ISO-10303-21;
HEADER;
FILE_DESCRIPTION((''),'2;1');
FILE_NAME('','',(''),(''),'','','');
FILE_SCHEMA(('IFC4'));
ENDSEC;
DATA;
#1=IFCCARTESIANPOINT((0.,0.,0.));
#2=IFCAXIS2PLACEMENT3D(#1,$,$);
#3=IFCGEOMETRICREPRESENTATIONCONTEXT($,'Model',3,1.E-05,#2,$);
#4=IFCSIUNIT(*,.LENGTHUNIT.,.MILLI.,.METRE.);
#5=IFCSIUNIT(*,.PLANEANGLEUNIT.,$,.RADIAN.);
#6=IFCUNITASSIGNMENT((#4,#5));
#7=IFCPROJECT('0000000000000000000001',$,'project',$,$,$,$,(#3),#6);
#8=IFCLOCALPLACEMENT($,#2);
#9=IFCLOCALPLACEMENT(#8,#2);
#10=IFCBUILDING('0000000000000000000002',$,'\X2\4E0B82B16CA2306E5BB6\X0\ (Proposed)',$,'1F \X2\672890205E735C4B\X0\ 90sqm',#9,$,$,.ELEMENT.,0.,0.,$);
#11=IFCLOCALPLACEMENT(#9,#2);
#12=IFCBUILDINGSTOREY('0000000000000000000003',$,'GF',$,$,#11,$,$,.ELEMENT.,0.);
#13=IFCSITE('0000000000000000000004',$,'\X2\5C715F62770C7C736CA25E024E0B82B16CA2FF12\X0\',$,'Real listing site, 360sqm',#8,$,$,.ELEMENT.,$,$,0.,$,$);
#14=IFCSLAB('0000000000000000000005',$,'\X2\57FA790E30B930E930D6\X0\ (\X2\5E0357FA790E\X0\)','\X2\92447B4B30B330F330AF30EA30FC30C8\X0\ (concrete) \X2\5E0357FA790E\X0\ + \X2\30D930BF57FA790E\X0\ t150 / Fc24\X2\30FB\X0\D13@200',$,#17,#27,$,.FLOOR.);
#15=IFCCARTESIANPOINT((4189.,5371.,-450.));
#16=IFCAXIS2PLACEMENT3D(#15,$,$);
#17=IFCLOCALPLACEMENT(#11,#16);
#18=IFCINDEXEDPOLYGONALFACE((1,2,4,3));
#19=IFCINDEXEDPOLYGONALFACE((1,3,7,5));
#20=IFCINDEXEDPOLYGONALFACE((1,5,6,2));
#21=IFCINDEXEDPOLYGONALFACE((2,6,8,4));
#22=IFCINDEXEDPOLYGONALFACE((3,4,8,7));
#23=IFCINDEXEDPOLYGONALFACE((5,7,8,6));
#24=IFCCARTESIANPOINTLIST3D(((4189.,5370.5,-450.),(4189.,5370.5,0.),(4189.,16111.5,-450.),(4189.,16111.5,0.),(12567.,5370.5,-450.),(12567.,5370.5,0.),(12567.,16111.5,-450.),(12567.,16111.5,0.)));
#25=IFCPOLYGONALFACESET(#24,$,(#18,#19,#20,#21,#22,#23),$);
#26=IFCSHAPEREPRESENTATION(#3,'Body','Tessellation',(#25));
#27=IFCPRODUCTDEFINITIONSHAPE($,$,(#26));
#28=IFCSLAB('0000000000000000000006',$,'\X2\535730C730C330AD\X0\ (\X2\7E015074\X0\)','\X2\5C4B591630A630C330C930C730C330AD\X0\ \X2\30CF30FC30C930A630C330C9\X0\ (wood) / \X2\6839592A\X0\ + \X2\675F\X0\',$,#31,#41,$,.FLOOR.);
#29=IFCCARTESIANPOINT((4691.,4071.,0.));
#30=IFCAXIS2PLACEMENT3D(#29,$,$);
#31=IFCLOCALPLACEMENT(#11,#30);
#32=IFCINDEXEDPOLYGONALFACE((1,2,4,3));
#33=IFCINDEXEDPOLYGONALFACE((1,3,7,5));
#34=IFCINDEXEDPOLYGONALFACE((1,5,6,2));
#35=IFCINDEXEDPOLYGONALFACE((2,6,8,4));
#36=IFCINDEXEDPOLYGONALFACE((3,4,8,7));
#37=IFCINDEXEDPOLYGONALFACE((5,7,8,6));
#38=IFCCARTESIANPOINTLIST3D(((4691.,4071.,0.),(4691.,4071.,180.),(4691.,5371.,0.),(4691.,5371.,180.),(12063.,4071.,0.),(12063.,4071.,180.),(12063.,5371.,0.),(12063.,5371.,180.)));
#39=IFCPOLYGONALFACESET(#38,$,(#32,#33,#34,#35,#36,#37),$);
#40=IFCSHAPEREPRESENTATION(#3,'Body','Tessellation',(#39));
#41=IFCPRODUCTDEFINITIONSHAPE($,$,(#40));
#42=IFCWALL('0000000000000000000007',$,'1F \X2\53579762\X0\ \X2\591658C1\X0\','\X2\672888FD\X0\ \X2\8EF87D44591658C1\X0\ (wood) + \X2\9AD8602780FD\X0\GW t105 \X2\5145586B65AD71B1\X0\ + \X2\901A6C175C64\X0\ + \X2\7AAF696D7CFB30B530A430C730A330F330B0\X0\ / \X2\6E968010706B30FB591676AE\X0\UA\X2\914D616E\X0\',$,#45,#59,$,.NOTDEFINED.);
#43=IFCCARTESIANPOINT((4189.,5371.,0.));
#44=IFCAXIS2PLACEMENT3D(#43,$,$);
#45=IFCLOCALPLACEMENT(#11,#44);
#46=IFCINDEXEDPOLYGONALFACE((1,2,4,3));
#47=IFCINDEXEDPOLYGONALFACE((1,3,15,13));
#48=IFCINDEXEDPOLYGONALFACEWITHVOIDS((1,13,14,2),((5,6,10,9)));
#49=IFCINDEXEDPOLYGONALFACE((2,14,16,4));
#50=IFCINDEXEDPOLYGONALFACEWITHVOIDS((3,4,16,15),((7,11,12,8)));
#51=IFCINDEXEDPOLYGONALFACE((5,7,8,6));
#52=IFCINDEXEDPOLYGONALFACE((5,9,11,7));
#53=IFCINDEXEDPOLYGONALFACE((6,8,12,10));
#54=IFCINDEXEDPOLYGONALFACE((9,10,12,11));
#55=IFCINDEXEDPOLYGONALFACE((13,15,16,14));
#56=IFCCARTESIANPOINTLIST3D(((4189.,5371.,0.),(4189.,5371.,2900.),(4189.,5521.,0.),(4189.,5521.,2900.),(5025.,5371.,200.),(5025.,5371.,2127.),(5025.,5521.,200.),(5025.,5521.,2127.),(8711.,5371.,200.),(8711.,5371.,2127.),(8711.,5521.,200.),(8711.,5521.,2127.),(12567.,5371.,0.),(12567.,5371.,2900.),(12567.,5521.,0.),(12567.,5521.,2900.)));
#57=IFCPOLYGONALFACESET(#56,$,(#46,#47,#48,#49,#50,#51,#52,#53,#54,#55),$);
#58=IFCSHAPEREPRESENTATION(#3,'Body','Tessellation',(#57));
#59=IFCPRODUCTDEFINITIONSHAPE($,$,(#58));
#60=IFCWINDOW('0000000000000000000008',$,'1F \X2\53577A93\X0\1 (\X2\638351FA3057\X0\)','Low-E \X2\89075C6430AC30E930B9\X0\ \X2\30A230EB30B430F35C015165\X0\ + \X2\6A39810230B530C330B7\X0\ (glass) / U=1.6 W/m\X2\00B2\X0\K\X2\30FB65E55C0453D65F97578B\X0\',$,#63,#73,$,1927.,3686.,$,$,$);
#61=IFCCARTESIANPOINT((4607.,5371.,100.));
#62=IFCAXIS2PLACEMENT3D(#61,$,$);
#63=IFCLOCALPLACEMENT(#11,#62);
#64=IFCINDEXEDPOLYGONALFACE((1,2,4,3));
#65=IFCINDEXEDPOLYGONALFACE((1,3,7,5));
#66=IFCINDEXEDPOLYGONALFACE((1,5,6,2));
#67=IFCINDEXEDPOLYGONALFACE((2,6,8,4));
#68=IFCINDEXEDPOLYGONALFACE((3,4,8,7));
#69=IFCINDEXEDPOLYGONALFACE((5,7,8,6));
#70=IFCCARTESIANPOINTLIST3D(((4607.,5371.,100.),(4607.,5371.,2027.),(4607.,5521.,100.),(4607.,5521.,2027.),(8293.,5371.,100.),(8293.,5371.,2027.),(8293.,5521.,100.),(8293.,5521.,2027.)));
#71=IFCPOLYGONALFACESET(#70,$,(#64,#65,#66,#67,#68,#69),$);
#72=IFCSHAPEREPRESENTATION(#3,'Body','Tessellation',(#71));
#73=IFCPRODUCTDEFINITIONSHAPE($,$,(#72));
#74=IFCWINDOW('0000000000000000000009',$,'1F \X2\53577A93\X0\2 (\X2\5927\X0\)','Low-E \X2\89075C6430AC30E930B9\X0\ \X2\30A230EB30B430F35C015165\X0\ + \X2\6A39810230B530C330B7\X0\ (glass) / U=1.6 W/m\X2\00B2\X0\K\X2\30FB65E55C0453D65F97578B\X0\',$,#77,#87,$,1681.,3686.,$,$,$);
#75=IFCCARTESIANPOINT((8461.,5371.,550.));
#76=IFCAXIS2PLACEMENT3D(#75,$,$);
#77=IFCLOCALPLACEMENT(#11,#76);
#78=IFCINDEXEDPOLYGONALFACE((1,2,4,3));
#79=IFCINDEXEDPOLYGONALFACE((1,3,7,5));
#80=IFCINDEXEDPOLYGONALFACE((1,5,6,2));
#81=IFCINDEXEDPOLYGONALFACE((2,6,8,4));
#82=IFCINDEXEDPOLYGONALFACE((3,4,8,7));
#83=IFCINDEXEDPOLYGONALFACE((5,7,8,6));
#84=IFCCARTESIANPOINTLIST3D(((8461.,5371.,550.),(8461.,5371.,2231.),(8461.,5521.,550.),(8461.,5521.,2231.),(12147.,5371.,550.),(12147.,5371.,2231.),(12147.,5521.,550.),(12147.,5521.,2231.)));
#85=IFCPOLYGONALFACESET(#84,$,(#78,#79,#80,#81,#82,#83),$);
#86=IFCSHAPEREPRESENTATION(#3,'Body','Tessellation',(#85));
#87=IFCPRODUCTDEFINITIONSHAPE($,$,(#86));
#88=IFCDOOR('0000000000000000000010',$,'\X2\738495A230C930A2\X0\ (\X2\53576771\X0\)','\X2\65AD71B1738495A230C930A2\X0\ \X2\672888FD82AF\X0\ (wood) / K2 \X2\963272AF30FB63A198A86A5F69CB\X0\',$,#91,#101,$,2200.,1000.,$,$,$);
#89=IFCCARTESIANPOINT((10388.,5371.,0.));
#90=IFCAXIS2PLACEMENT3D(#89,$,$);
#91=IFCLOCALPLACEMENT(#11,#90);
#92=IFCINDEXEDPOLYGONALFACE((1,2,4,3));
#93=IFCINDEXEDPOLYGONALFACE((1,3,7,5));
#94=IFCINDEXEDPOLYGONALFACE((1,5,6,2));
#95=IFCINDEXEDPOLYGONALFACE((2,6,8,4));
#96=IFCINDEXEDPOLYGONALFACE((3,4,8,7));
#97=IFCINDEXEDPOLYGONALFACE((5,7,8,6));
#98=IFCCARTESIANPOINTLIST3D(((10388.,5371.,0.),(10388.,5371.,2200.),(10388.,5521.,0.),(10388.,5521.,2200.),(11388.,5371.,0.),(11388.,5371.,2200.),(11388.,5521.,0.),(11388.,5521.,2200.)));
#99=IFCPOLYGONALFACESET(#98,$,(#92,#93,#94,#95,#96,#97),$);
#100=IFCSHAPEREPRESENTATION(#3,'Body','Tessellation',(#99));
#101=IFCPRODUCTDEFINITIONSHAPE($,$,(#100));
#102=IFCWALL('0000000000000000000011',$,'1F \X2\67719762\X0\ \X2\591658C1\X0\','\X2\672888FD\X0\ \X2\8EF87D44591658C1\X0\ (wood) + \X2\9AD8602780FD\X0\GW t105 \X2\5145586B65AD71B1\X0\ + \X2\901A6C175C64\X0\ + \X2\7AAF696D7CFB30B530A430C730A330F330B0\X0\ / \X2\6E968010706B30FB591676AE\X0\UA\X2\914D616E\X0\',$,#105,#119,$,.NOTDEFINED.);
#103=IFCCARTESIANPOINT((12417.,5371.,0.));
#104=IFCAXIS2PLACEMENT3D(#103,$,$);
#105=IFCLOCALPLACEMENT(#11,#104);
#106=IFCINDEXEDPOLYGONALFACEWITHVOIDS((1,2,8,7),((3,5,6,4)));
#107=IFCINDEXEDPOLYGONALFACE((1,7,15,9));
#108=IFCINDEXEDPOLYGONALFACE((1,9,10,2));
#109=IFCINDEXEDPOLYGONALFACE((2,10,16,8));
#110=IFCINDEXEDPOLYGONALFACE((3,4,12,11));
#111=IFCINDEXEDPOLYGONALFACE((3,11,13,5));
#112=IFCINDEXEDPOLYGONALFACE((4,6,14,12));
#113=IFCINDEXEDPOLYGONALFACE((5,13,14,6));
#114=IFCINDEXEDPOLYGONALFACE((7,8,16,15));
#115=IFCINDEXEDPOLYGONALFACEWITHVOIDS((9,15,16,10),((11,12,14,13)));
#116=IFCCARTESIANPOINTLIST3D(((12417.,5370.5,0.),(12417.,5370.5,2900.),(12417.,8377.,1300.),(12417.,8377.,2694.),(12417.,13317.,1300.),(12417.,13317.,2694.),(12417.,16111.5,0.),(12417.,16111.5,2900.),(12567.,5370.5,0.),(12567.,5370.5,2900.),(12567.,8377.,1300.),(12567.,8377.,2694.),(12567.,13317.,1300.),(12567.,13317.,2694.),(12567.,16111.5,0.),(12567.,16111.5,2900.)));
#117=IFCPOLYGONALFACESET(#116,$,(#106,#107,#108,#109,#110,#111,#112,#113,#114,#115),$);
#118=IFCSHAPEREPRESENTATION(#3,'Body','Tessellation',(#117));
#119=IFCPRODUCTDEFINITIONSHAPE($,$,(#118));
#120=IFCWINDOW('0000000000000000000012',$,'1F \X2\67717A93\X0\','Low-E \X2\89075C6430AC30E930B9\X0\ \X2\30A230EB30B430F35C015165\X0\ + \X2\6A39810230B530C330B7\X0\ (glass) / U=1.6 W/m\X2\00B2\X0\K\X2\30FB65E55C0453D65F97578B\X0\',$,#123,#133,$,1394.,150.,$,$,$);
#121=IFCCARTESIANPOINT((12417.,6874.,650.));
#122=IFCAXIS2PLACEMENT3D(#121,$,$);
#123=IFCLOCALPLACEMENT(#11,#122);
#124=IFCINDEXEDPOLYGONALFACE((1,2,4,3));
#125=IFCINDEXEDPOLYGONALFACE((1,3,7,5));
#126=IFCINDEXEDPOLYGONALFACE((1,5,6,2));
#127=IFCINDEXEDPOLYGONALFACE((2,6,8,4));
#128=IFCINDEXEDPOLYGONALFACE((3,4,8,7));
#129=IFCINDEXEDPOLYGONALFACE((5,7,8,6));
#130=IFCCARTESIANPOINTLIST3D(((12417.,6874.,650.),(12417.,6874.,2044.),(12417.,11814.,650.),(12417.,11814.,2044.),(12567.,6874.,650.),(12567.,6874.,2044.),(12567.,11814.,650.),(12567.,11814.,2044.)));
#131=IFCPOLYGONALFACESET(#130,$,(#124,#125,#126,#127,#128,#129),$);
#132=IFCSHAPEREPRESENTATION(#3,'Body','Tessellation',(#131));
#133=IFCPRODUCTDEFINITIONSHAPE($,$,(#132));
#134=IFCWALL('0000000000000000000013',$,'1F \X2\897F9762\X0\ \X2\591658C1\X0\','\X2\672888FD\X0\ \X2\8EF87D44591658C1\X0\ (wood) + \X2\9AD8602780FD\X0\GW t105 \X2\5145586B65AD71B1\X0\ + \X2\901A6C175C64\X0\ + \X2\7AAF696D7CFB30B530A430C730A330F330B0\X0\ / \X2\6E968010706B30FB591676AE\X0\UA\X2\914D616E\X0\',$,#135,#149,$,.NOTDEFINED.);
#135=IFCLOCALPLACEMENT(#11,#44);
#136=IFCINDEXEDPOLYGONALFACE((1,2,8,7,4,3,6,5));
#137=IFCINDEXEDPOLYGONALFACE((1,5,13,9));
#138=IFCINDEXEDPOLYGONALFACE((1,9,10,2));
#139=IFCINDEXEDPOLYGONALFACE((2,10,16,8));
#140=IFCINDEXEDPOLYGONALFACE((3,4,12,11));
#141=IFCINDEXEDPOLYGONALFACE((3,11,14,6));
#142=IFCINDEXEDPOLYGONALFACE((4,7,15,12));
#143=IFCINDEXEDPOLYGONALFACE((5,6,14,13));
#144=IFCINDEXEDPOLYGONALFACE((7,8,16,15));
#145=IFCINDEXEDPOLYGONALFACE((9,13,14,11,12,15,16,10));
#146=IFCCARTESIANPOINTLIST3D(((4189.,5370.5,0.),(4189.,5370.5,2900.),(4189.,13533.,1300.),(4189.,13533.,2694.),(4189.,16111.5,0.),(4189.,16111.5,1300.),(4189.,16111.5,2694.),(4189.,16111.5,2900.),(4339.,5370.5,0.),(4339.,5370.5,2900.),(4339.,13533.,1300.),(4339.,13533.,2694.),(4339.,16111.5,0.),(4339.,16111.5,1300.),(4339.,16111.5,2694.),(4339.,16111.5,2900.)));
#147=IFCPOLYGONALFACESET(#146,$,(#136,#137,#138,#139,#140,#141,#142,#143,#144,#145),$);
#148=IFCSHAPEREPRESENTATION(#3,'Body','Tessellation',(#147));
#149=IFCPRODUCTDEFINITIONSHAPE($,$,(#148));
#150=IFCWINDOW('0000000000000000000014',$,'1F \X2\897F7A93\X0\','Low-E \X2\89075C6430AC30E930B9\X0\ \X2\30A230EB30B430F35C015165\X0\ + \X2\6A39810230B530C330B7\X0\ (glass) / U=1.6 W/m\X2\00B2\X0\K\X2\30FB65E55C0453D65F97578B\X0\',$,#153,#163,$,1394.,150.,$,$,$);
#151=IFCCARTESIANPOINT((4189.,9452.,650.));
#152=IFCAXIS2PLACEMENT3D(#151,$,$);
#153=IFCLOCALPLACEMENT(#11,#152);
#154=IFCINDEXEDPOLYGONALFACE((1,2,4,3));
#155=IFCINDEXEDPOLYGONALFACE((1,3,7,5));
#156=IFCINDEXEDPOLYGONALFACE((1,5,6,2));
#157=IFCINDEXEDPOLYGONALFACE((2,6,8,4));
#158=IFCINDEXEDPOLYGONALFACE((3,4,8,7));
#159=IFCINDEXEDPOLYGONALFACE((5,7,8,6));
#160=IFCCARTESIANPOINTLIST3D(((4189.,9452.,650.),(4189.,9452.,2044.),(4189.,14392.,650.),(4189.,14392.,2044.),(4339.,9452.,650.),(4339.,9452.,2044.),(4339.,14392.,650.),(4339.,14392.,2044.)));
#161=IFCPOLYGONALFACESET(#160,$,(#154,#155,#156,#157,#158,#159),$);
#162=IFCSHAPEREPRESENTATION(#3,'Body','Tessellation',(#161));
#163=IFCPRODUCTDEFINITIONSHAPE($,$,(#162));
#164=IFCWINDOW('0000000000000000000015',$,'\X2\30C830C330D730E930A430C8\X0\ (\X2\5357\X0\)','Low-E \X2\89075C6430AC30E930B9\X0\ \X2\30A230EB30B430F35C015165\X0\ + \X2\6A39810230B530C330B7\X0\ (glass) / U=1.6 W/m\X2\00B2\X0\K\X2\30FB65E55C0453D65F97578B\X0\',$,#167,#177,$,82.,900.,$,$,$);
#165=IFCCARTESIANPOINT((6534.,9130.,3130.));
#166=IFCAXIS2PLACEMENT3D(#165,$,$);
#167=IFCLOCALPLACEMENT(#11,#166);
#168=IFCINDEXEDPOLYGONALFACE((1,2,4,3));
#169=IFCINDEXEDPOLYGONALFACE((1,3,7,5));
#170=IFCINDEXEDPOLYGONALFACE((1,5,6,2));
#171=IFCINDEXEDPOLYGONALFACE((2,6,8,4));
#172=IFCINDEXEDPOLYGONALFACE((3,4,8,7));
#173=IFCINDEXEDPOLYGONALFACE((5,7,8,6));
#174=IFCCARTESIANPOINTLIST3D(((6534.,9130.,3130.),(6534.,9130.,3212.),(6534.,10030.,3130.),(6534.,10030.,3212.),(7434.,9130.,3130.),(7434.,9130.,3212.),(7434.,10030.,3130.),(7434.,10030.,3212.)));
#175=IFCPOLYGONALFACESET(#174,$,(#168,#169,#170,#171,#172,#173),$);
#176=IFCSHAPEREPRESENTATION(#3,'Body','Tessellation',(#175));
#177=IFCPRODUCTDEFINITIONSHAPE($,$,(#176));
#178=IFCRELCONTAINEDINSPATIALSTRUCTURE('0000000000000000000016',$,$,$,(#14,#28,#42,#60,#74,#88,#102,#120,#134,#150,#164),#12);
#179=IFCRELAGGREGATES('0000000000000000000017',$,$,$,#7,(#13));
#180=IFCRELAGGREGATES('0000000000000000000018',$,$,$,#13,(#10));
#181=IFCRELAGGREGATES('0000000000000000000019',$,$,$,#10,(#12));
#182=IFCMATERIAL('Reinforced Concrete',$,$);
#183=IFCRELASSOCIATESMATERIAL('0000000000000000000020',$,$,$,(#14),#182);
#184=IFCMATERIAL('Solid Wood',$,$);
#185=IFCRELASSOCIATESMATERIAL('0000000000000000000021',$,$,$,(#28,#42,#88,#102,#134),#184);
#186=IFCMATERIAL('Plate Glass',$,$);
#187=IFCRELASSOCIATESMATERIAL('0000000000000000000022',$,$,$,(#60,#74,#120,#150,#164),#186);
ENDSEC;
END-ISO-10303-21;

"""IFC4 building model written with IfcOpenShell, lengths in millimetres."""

from ifc_helpers import new_model, si_unit, frame, frame_2d, origin, place, context, project, spatial, rectangle, extrude, material, element, fill, save


model = new_model("IFC4")

# Units and contexts
model_context = context("Model", 3, precision=1e-05, world=origin())
ifc_project = project(units=[si_unit("LENGTHUNIT", "METRE", prefix="MILLI"), si_unit("PLANEANGLEUNIT", "RADIAN")], contexts=[model_context])

# Site, building, storey
site_placement = place(None, origin())
site = spatial("IfcSite", under=ifc_project, at=site_placement, Name="山形県米沢市下花沢２", ObjectType="Real listing site, 360sqm", CompositionType="ELEMENT", RefElevation=0.0)
building_placement = place(site_placement, origin())
building = spatial("IfcBuilding", under=site, at=building_placement, Name="下花沢の家 (Proposed)", ObjectType="1F 木造平屋 90sqm", CompositionType="ELEMENT", ElevationOfRefHeight=0.0, ElevationOfTerrain=0.0)
storey_placement = place(building_placement, origin())
storey = spatial("IfcBuildingStorey", under=building, at=storey_placement, Name="GF", CompositionType="ELEMENT", Elevation=0.0)

# Slabs
ifc_material_1 = material(Name="Reinforced Concrete")
slab_1_placement = place(storey_placement, frame((4189.0, 5371.0, -450.0)))
element("IfcSlab", 1, at=slab_1_placement, inside=storey, material=ifc_material_1, Name="基礎スラブ (布基礎)", Description="鉄筋コンクリート (concrete) 布基礎 + ベタ基礎 t150 / Fc24・D13@200", PredefinedType="FLOOR", context=model_context, shape_type="SweptSolid", body=[
    extrude(rectangle(XDim=8378.0, YDim=10741.0, at=frame_2d((4189.0, 5370.0))), frame((4189.0, 5371.0, -450.0)), (0.0, 0.0, 1.0), 450.0),
])
ifc_material_2 = material(Name="Solid Wood")
slab_2_placement = place(storey_placement, frame((4691.0, 4071.0, 0.0)))
element("IfcSlab", 2, at=slab_2_placement, inside=storey, material=ifc_material_2, Name="南デッキ (縁側)", Description="屋外ウッドデッキ ハードウッド (wood) / 根太 + 束", PredefinedType="FLOOR", context=model_context, shape_type="SweptSolid", body=[
    extrude(rectangle(XDim=7372.0, YDim=1300.0, at=frame_2d((3686.0, 650.0))), frame((4691.0, 4071.0, 0.0)), (0.0, 0.0, 1.0), 180.0),
])

# Wall, openings, windows, door
wall_1_placement = place(storey_placement, frame((4189.0, 5371.0, 0.0)))
wall_1 = element("IfcWall", 3, at=wall_1_placement, inside=storey, material=ifc_material_2, Name="1F 南面 外壁", Description="木製 軸組外壁 (wood) + 高性能GW t105 充填断熱 + 通気層 + 窯業系サイディング / 準耐火・外皮UA配慮", PredefinedType="NOTDEFINED", context=model_context, shape_type="SweptSolid", body=[
    extrude(rectangle(XDim=8378.0, YDim=150.0, at=frame_2d((4189.0, 75.0))), frame((4189.0, 5371.0, 0.0)), (0.0, 0.0, 1.0), 2900.0),
])
opening_1_placement = place(storey_placement, frame((4607.0, 5371.0, 100.0)))
opening_1 = element("IfcOpeningElement", 4, at=opening_1_placement, cuts=wall_1, PredefinedType="NOTDEFINED", context=model_context, shape_type="SweptSolid", body=[
    extrude(rectangle(XDim=3686.0, YDim=150.0, at=frame_2d((1843.0, 75.0))), frame((4607.0, 5371.0, 100.0)), (0.0, 0.0, 1.0), 1927.0),
])
opening_2_placement = place(storey_placement, frame((8461.0, 5371.0, 550.0)))
opening_2 = element("IfcOpeningElement", 5, at=opening_2_placement, cuts=wall_1, PredefinedType="NOTDEFINED", context=model_context, shape_type="SweptSolid", body=[
    extrude(rectangle(XDim=3686.0, YDim=150.0, at=frame_2d((1843.0, 75.0))), frame((8461.0, 5371.0, 550.0)), (0.0, 0.0, 1.0), 1681.0),
])
opening_3_placement = place(storey_placement, frame((10388.0, 5371.0, 0.0)))
opening_3 = element("IfcOpeningElement", 6, at=opening_3_placement, cuts=wall_1, PredefinedType="NOTDEFINED", context=model_context, shape_type="SweptSolid", body=[
    extrude(rectangle(XDim=1000.0, YDim=150.0, at=frame_2d((500.0, 75.0))), frame((10388.0, 5371.0, 0.0)), (0.0, 0.0, 1.0), 2200.0),
])
ifc_material_3 = material(Name="Plate Glass")
window_1_placement = place(storey_placement, frame((4607.0, 5371.0, 100.0)))
window_1 = element("IfcWindow", 7, at=window_1_placement, inside=storey, material=ifc_material_3, Name="1F 南窓1 (掃出し)", Description="Low-E 複層ガラス アルゴン封入 + 樹脂サッシ (glass) / U=1.6 W/m²K・日射取得型", OverallHeight=1927.0, OverallWidth=3686.0, context=model_context, shape_type="SweptSolid", body=[
    extrude(rectangle(XDim=3686.0, YDim=150.0, at=frame_2d((1843.0, 75.0))), frame((4607.0, 5371.0, 100.0)), (0.0, 0.0, 1.0), 1927.0),
])
fill(opening_1, window_1)
window_2_placement = place(storey_placement, frame((8461.0, 5371.0, 550.0)))
window_2 = element("IfcWindow", 8, at=window_2_placement, inside=storey, material=ifc_material_3, Name="1F 南窓2 (大)", Description="Low-E 複層ガラス アルゴン封入 + 樹脂サッシ (glass) / U=1.6 W/m²K・日射取得型", OverallHeight=1681.0, OverallWidth=3686.0, context=model_context, shape_type="SweptSolid", body=[
    extrude(rectangle(XDim=3686.0, YDim=150.0, at=frame_2d((1843.0, 75.0))), frame((8461.0, 5371.0, 550.0)), (0.0, 0.0, 1.0), 1681.0),
])
fill(opening_2, window_2)
door_placement = place(storey_placement, frame((10388.0, 5371.0, 0.0)))
door = element("IfcDoor", 9, at=door_placement, inside=storey, material=ifc_material_2, Name="玄関ドア (南東)", Description="断熱玄関ドア 木製芯 (wood) / K2 防犯・採風機構", OverallHeight=2200.0, OverallWidth=1000.0, context=model_context, shape_type="SweptSolid", body=[
    extrude(rectangle(XDim=1000.0, YDim=150.0, at=frame_2d((500.0, 75.0))), frame((10388.0, 5371.0, 0.0)), (0.0, 0.0, 1.0), 2200.0),
])
fill(opening_3, door)

# Walls, openings, windows
wall_2_placement = place(storey_placement, frame((12417.0, 5371.0, 0.0)))
wall_2 = element("IfcWall", 10, at=wall_2_placement, inside=storey, material=ifc_material_2, Name="1F 東面 外壁", Description="木製 軸組外壁 (wood) + 高性能GW t105 充填断熱 + 通気層 + 窯業系サイディング / 準耐火・外皮UA配慮", PredefinedType="NOTDEFINED", context=model_context, shape_type="SweptSolid", body=[
    extrude(rectangle(XDim=150.0, YDim=10741.0, at=frame_2d((75.0, 5370.0))), frame((12417.0, 5371.0, 0.0)), (0.0, 0.0, 1.0), 2900.0),
])
opening_4_placement = place(storey_placement, frame((12417.0, 6874.0, 650.0)))
opening_4 = element("IfcOpeningElement", 11, at=opening_4_placement, cuts=wall_2, PredefinedType="NOTDEFINED", context=model_context, shape_type="SweptSolid", body=[
    extrude(rectangle(XDim=150.0, YDim=4940.0, at=frame_2d((75.0, 2470.0))), frame((12417.0, 6874.0, 650.0)), (0.0, 0.0, 1.0), 1394.0),
])
window_3_placement = place(storey_placement, frame((12417.0, 6874.0, 650.0)))
window_3 = element("IfcWindow", 12, at=window_3_placement, inside=storey, material=ifc_material_3, Name="1F 東窓", Description="Low-E 複層ガラス アルゴン封入 + 樹脂サッシ (glass) / U=1.6 W/m²K・日射取得型", OverallHeight=1394.0, OverallWidth=150.0, context=model_context, shape_type="SweptSolid", body=[
    extrude(rectangle(XDim=150.0, YDim=4940.0, at=frame_2d((75.0, 2470.0))), frame((12417.0, 6874.0, 650.0)), (0.0, 0.0, 1.0), 1394.0),
])
fill(opening_4, window_3)
wall_3_placement = place(storey_placement, frame((4189.0, 5371.0, 0.0)))
wall_3 = element("IfcWall", 13, at=wall_3_placement, inside=storey, material=ifc_material_2, Name="1F 西面 外壁", Description="木製 軸組外壁 (wood) + 高性能GW t105 充填断熱 + 通気層 + 窯業系サイディング / 準耐火・外皮UA配慮", PredefinedType="NOTDEFINED", context=model_context, shape_type="SweptSolid", body=[
    extrude(rectangle(XDim=150.0, YDim=10741.0, at=frame_2d((75.0, 5370.0))), frame((4189.0, 5371.0, 0.0)), (0.0, 0.0, 1.0), 2900.0),
])
opening_5_placement = place(storey_placement, frame((4189.0, 9452.0, 650.0)))
opening_5 = element("IfcOpeningElement", 14, at=opening_5_placement, cuts=wall_3, PredefinedType="NOTDEFINED", context=model_context, shape_type="SweptSolid", body=[
    extrude(rectangle(XDim=150.0, YDim=4940.0, at=frame_2d((75.0, 2470.0))), frame((4189.0, 9452.0, 650.0)), (0.0, 0.0, 1.0), 1394.0),
])
window_4_placement = place(storey_placement, frame((4189.0, 9452.0, 650.0)))
window_4 = element("IfcWindow", 15, at=window_4_placement, inside=storey, material=ifc_material_3, Name="1F 西窓", Description="Low-E 複層ガラス アルゴン封入 + 樹脂サッシ (glass) / U=1.6 W/m²K・日射取得型", OverallHeight=1394.0, OverallWidth=150.0, context=model_context, shape_type="SweptSolid", body=[
    extrude(rectangle(XDim=150.0, YDim=4940.0, at=frame_2d((75.0, 2470.0))), frame((4189.0, 9452.0, 650.0)), (0.0, 0.0, 1.0), 1394.0),
])
fill(opening_5, window_4)

# Window
window_5_placement = place(storey_placement, frame((6534.0, 9130.0, 3130.0)))
element("IfcWindow", 16, at=window_5_placement, inside=storey, material=ifc_material_3, Name="トップライト (南)", Description="Low-E 複層ガラス アルゴン封入 + 樹脂サッシ (glass) / U=1.6 W/m²K・日射取得型", OverallHeight=82.0, OverallWidth=900.0, context=model_context, shape_type="SweptSolid", body=[
    extrude(rectangle(XDim=900.0, YDim=900.0, at=frame_2d((450.0, 450.0))), frame((6534.0, 9130.0, 3130.0)), (0.0, 0.0, 1.0), 82.0),
])

save(model, "model.ifc")
